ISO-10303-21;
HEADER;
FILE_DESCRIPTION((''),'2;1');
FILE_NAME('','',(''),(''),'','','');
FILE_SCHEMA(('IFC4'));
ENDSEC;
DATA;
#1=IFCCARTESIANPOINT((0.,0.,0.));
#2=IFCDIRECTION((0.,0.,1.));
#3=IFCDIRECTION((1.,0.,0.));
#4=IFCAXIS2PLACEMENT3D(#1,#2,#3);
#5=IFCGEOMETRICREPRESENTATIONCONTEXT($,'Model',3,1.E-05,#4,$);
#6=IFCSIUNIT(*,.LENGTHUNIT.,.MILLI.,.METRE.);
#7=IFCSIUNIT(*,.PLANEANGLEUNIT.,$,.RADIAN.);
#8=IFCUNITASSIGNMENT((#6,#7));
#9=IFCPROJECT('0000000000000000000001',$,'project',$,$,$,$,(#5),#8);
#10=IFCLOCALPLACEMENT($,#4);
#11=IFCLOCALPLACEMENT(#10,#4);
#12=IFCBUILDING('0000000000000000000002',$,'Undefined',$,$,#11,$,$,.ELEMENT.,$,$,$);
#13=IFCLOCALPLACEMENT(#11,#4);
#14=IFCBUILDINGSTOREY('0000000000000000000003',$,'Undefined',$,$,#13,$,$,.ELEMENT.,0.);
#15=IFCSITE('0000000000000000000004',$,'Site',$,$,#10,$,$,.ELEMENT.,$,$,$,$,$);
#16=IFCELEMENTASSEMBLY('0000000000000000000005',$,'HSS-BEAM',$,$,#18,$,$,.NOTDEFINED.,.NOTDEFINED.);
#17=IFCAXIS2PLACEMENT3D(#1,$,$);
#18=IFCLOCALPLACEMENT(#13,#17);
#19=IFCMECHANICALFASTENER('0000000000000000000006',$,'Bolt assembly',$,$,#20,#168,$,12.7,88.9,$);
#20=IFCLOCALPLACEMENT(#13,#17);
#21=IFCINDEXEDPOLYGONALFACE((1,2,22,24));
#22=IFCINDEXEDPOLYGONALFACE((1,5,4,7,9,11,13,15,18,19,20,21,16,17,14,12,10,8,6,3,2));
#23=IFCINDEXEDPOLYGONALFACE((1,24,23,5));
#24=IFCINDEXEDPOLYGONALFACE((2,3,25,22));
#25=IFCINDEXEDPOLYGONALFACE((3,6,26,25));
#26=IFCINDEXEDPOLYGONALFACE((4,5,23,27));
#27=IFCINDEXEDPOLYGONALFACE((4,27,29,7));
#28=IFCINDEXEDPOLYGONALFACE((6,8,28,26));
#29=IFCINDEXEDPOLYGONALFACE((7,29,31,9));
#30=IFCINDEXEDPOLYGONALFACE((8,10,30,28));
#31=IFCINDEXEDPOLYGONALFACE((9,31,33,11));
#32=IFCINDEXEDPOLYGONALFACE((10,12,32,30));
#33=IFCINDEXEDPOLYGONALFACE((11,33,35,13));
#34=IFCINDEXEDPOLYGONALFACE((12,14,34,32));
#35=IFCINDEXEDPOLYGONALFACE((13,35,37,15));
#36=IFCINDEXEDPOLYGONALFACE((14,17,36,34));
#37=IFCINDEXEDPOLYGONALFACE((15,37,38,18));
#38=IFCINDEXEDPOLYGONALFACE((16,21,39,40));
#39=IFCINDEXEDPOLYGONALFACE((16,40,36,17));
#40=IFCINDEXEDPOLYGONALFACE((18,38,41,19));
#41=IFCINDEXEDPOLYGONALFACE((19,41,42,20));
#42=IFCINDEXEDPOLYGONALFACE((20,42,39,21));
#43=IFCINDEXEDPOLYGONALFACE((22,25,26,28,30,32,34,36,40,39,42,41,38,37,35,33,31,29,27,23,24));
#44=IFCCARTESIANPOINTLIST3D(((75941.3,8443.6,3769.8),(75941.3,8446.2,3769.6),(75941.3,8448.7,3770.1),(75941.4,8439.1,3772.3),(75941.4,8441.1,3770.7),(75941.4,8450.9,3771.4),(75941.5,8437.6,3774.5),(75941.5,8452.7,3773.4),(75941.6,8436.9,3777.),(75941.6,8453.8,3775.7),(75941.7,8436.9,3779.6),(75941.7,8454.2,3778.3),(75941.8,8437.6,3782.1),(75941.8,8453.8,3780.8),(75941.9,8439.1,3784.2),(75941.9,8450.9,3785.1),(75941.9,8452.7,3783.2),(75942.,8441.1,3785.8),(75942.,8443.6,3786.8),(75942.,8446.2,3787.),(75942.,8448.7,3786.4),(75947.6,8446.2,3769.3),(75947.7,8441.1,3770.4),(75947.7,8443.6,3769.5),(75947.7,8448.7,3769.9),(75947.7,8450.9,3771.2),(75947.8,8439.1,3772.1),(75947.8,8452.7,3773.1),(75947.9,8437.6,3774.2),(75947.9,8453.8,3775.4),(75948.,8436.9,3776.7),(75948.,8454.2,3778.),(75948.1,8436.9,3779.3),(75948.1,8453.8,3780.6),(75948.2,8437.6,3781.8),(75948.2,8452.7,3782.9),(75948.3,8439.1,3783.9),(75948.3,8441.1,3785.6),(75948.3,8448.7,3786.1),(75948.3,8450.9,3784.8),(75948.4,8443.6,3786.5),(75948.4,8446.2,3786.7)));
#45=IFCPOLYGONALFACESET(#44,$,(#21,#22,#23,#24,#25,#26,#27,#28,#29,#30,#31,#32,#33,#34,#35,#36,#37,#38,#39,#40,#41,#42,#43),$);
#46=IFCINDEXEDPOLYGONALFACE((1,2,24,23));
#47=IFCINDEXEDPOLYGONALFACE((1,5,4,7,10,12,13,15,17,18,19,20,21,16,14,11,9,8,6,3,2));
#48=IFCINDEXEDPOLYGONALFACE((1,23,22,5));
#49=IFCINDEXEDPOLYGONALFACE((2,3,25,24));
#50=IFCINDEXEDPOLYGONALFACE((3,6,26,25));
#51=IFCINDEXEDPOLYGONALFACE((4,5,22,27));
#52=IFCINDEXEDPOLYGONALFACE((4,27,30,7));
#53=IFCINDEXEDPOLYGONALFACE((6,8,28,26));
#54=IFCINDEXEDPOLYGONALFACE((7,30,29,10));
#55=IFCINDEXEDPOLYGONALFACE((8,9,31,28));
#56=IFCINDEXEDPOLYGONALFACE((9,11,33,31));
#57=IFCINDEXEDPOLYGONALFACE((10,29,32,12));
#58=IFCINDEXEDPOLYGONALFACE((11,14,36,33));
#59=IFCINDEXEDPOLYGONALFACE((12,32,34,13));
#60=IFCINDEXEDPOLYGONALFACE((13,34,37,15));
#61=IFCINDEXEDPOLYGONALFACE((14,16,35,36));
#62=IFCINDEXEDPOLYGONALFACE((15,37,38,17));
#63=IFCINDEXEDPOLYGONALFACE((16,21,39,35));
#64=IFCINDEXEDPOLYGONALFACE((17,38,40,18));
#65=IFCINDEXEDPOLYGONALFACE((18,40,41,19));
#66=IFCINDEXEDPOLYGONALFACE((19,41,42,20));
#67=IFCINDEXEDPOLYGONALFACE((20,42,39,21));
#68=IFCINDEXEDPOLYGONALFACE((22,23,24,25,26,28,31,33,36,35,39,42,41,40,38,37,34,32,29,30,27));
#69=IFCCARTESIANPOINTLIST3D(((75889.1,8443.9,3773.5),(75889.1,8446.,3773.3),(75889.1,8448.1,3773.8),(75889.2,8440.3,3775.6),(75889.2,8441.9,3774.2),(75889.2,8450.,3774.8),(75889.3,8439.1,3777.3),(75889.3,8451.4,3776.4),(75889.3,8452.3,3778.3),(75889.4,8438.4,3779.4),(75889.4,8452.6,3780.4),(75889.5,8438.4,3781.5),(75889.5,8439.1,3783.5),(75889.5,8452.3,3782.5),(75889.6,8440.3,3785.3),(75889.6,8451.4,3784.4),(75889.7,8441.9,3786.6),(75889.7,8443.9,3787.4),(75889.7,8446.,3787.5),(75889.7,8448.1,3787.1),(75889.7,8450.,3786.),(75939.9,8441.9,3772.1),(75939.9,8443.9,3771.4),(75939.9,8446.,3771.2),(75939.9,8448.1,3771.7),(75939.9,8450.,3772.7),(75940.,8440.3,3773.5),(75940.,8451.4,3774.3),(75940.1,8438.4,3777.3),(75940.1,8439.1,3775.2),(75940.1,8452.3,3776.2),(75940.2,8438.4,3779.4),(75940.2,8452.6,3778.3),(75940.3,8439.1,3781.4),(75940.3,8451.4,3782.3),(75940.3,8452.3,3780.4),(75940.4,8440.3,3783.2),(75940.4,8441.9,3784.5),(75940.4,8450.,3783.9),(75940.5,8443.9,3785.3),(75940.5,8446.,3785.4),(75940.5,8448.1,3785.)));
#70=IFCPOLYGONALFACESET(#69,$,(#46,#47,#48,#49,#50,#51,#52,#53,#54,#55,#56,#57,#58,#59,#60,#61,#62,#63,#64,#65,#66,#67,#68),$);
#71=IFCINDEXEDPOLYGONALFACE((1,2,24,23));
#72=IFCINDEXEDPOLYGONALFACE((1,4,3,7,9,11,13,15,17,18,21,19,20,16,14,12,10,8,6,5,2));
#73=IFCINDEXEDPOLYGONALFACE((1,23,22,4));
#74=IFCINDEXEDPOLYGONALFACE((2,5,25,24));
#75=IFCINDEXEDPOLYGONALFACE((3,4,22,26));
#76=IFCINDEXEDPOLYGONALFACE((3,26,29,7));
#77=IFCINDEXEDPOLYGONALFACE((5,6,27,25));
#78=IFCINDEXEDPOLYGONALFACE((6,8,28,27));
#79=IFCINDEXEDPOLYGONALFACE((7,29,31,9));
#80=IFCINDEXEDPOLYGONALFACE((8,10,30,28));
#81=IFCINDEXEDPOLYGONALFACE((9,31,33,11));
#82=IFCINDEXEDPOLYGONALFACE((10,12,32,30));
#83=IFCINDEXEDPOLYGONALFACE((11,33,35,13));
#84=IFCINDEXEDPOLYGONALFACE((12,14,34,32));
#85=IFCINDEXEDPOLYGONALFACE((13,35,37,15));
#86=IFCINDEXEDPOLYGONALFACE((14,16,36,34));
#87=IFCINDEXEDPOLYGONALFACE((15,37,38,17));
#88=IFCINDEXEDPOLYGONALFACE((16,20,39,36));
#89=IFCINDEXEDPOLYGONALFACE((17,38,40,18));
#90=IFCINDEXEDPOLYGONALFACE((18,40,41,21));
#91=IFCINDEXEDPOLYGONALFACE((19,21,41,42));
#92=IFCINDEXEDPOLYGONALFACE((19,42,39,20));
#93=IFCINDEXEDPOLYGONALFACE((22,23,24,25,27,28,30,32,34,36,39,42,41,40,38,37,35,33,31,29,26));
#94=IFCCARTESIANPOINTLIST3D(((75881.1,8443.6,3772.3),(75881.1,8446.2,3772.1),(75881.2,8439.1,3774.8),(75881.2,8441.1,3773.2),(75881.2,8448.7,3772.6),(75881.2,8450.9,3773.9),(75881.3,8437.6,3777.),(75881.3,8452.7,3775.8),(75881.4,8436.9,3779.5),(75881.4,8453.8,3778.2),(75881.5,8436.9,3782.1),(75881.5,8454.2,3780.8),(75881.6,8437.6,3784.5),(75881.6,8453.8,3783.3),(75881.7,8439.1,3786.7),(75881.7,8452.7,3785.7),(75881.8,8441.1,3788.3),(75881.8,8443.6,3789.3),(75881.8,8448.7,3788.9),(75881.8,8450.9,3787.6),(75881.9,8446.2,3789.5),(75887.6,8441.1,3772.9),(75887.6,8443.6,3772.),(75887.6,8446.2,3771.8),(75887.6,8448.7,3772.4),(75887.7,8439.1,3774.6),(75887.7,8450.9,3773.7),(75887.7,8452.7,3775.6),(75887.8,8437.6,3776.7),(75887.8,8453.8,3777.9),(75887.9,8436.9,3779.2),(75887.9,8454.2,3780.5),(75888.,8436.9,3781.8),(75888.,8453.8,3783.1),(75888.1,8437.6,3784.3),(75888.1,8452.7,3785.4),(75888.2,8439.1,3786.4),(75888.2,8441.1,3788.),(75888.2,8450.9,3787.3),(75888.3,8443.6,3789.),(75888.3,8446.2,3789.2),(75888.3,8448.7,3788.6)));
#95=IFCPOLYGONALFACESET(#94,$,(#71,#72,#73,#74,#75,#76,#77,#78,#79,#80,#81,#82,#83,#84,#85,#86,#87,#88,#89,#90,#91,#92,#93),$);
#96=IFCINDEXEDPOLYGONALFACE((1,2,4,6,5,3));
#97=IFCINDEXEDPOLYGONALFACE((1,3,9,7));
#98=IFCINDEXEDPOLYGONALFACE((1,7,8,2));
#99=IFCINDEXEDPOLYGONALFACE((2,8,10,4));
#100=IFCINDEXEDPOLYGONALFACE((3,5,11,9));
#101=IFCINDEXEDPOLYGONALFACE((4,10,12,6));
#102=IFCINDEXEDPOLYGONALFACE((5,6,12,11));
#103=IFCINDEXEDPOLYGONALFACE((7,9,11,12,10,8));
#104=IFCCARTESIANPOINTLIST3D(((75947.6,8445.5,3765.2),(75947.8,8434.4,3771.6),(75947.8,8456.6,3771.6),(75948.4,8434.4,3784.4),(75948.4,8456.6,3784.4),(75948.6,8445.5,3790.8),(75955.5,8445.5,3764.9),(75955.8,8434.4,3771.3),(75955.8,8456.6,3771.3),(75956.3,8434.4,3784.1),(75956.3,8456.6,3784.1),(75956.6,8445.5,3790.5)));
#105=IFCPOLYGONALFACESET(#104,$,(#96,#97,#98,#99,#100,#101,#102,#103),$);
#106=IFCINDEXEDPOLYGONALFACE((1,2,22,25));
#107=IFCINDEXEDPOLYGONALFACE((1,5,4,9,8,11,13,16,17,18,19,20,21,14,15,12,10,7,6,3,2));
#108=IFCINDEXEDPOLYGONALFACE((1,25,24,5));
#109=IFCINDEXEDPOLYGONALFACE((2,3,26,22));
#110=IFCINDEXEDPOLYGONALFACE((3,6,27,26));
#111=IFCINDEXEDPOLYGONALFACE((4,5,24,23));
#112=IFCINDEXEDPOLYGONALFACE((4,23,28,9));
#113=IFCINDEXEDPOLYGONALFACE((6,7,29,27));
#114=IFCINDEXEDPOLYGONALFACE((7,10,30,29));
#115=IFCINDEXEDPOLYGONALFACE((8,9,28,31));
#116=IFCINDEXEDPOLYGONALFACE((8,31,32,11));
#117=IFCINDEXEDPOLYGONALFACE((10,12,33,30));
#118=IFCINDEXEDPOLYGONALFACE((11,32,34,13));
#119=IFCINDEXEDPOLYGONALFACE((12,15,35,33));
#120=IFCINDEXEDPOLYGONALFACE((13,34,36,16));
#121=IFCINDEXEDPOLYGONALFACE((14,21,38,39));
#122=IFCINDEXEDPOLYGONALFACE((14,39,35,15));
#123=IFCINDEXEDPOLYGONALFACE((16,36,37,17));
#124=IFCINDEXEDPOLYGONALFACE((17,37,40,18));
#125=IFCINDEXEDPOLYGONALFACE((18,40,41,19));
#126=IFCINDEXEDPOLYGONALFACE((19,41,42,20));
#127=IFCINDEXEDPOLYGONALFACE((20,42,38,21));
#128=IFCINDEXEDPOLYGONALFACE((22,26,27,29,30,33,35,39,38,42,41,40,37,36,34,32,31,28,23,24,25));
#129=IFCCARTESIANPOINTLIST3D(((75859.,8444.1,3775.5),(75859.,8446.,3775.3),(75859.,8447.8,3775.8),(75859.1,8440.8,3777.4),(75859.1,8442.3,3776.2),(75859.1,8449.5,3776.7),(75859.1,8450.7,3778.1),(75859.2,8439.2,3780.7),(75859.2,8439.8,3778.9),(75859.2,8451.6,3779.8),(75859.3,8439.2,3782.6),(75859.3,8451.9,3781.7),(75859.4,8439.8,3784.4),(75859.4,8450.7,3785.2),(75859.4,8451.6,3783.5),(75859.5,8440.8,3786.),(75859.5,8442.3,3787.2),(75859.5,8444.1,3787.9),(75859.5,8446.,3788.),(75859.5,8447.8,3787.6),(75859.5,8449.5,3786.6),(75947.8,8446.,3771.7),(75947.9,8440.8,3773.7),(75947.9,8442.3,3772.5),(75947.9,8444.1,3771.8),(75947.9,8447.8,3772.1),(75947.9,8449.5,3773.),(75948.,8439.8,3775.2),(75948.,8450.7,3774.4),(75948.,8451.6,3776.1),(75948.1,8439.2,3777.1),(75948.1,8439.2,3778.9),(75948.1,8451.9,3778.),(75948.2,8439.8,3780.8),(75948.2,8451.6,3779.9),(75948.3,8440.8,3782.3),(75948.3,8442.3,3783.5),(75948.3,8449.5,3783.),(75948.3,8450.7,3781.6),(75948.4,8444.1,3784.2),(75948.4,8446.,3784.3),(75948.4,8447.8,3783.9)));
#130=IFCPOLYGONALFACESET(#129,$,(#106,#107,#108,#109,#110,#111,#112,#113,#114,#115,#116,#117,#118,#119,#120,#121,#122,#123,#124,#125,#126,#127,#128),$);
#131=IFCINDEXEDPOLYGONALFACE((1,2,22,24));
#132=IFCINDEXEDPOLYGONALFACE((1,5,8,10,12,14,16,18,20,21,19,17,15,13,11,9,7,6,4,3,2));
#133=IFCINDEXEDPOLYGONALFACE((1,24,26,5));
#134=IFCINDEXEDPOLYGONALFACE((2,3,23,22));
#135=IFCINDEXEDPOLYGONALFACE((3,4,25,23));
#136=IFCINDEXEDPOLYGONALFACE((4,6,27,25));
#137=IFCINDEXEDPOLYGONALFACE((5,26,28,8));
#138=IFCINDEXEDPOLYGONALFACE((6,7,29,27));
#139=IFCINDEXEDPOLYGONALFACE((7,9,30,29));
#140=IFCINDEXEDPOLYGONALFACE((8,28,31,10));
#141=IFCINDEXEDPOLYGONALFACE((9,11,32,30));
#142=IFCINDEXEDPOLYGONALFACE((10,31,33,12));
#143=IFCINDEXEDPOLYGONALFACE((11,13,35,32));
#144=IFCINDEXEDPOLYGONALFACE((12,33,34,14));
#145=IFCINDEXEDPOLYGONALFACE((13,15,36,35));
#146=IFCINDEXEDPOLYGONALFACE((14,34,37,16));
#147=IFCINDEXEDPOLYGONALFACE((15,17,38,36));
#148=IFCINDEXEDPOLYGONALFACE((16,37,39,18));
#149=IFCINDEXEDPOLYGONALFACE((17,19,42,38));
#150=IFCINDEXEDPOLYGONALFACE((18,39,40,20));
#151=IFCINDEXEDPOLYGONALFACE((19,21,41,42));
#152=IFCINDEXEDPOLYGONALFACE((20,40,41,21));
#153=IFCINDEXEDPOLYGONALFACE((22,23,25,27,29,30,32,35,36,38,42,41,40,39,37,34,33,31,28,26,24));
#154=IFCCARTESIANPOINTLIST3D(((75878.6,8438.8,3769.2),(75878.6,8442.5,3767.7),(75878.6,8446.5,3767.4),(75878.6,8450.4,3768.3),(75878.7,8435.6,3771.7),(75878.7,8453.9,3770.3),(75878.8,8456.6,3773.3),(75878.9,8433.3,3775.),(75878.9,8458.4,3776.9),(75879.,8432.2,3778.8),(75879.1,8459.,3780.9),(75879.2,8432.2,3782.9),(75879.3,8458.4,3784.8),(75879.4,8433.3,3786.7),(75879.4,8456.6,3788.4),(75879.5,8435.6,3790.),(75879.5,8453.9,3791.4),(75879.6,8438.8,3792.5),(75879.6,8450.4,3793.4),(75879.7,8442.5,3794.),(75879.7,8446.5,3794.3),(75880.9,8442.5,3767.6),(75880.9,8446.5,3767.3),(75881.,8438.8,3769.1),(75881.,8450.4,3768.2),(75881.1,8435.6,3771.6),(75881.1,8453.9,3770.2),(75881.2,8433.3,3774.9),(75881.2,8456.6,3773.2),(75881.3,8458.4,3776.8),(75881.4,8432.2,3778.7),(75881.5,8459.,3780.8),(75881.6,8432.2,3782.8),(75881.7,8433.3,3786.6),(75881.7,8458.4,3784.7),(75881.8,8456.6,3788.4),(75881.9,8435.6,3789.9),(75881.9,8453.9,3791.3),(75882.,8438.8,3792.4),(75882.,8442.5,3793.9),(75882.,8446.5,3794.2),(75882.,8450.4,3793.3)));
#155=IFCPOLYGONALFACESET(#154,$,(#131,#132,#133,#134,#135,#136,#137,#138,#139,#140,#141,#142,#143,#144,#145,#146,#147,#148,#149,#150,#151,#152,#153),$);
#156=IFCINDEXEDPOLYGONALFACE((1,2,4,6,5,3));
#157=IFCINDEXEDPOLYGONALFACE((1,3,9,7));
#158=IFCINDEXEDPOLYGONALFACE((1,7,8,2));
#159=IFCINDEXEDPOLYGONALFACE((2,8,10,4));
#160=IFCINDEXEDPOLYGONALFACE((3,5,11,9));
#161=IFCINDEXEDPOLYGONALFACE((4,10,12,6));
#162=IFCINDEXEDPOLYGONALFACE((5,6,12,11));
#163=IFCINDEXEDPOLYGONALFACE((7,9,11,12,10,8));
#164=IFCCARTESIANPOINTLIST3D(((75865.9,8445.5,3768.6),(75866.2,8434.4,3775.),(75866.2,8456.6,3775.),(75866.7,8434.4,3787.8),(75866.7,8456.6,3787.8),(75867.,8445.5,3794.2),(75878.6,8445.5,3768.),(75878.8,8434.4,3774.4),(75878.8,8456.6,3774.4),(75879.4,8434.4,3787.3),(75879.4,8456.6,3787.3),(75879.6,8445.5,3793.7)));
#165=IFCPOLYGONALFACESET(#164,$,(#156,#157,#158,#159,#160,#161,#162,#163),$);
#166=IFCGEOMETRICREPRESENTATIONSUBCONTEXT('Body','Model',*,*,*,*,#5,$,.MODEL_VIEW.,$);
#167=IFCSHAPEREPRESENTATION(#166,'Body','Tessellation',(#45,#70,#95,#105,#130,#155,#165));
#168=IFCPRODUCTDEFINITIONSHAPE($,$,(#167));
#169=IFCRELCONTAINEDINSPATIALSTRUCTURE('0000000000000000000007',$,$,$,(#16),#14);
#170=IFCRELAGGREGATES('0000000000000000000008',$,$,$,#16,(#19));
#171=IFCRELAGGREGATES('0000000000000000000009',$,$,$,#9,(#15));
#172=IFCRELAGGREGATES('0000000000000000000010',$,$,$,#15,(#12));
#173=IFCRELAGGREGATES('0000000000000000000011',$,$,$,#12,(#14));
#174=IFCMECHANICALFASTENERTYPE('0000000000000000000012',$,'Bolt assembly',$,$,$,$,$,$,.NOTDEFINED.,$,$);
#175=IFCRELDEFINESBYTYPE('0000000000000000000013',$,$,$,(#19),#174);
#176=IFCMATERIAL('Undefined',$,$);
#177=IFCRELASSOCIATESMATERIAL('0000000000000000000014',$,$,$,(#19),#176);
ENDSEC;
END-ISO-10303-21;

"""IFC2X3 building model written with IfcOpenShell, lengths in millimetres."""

from ifc_helpers import new_model, si_unit, frame, origin_with_axes, origin_2d_with_axis, place, context, subcontext, project, spatial, polyline, circle, outline, extrude, source, transform, mapped, material, type_object, element, aggregate, save


model = new_model("IFC2X3")

# Units and contexts
model_context = context("Model", 3, precision=1e-05, world=origin_with_axes())
body_context = subcontext(model_context, "Body", "Model", "MODEL_VIEW")
ifc_project = project(units=[si_unit("LENGTHUNIT", "METRE", prefix="MILLI"), si_unit("PLANEANGLEUNIT", "RADIAN")], contexts=[model_context])

# Site, building, storey
site_placement = place(None, origin_with_axes())
site = spatial("IfcSite", under=ifc_project, at=site_placement, Name="Site", CompositionType="ELEMENT")
building_placement = place(site_placement, origin_with_axes())
building = spatial("IfcBuilding", under=site, at=building_placement, Name="Undefined", CompositionType="ELEMENT")
storey_placement = place(building_placement, origin_with_axes())
storey = spatial("IfcBuildingStorey", under=building, at=storey_placement, Name="Undefined", CompositionType="ELEMENT", Elevation=0.0)

# Element assembly
assembly_1_placement = place(storey_placement, origin_with_axes())
assembly_1 = element("IfcElementAssembly", 1, at=assembly_1_placement, inside=storey, Name="HSS-BEAM", AssemblyPlace="NOTDEFINED", PredefinedType="NOTDEFINED")

# Mechanical fastener
ifc_material_1 = material(Name="Undefined")
mechanical_fastener_type = type_object("IfcMechanicalFastenerType", Name="Bolt assembly")
shared_shape_1 = source(origin_with_axes(), body_context, "Body", "SweptSolid", [
    extrude(circle(Radius=8.7, at=origin_2d_with_axis()), frame((0.0, -33.2, 0.0), z_axis=(0.0, 1.0, 0.0), x_axis=(1.0, 0.0, 0.0)), (0.0, 0.0, 1.0), 6.3),
    extrude(circle(Radius=7.1, at=origin_2d_with_axis()), frame((0.0, -25.4, 0.0), z_axis=(0.0, 1.0, 0.0), x_axis=(1.0, 0.0, 0.0)), (0.0, 0.0, 1.0), 50.8),
    extrude(circle(Radius=8.7, at=origin_2d_with_axis()), frame((0.0, 26.9, 0.0), z_axis=(0.0, 1.0, 0.0), x_axis=(1.0, 0.0, 0.0)), (0.0, 0.0, 1.0), 6.5),
    extrude(outline(polyline([(11.1, -6.4), (11.1, 6.4), (0.0, 12.8), (-11.1, 6.4), (-11.1, -6.4), (0.0, -12.8), (11.1, -6.4)])), frame((0.0, -41.3, 0.0), z_axis=(0.0, 1.0, 0.0), x_axis=(1.0, 0.0, 0.0)), (0.0, 0.0, 1.0), 7.9),
    extrude(circle(Radius=6.3, at=origin_2d_with_axis()), frame((0.0, -33.3, 0.0), z_axis=(0.0, 1.0, 0.0), x_axis=(1.0, 0.0, 0.0)), (0.0, 0.0, 1.0), 88.9),
    extrude(circle(Radius=13.5, at=origin_2d_with_axis()), frame((0.0, 33.3, 0.0), z_axis=(0.0, 1.0, 0.0), x_axis=(1.0, 0.0, 0.0)), (0.0, 0.0, 1.0), 2.4),
    extrude(outline(polyline([(11.1, -6.4), (11.1, 6.4), (0.0, 12.8), (-11.1, 6.4), (-11.1, -6.4), (0.0, -12.8), (11.1, -6.4)])), frame((0.0, 35.7, 0.0), z_axis=(0.0, 1.0, 0.0), x_axis=(1.0, 0.0, 0.0)), (0.0, 0.0, 1.0), 12.7),
])
mechanical_fastener_1_placement = place(assembly_1_placement, frame((75914.8, 8445.5, 3779.4), z_axis=(0.041337, 0.0, 0.999145), x_axis=(0.0, 1.0, 0.0)))
mechanical_fastener_1 = element("IfcMechanicalFastener", 2, at=mechanical_fastener_1_placement, type_object=mechanical_fastener_type, material=ifc_material_1, Name="Bolt assembly", NominalDiameter=12.7, NominalLength=88.9, context=body_context, shape_type="MappedRepresentation", body=[
    mapped(shared_shape_1, transform((0.0, 0.0, 0.0))),
])

aggregate(assembly_1, [mechanical_fastener_1])

save(model, "model.ifc")
